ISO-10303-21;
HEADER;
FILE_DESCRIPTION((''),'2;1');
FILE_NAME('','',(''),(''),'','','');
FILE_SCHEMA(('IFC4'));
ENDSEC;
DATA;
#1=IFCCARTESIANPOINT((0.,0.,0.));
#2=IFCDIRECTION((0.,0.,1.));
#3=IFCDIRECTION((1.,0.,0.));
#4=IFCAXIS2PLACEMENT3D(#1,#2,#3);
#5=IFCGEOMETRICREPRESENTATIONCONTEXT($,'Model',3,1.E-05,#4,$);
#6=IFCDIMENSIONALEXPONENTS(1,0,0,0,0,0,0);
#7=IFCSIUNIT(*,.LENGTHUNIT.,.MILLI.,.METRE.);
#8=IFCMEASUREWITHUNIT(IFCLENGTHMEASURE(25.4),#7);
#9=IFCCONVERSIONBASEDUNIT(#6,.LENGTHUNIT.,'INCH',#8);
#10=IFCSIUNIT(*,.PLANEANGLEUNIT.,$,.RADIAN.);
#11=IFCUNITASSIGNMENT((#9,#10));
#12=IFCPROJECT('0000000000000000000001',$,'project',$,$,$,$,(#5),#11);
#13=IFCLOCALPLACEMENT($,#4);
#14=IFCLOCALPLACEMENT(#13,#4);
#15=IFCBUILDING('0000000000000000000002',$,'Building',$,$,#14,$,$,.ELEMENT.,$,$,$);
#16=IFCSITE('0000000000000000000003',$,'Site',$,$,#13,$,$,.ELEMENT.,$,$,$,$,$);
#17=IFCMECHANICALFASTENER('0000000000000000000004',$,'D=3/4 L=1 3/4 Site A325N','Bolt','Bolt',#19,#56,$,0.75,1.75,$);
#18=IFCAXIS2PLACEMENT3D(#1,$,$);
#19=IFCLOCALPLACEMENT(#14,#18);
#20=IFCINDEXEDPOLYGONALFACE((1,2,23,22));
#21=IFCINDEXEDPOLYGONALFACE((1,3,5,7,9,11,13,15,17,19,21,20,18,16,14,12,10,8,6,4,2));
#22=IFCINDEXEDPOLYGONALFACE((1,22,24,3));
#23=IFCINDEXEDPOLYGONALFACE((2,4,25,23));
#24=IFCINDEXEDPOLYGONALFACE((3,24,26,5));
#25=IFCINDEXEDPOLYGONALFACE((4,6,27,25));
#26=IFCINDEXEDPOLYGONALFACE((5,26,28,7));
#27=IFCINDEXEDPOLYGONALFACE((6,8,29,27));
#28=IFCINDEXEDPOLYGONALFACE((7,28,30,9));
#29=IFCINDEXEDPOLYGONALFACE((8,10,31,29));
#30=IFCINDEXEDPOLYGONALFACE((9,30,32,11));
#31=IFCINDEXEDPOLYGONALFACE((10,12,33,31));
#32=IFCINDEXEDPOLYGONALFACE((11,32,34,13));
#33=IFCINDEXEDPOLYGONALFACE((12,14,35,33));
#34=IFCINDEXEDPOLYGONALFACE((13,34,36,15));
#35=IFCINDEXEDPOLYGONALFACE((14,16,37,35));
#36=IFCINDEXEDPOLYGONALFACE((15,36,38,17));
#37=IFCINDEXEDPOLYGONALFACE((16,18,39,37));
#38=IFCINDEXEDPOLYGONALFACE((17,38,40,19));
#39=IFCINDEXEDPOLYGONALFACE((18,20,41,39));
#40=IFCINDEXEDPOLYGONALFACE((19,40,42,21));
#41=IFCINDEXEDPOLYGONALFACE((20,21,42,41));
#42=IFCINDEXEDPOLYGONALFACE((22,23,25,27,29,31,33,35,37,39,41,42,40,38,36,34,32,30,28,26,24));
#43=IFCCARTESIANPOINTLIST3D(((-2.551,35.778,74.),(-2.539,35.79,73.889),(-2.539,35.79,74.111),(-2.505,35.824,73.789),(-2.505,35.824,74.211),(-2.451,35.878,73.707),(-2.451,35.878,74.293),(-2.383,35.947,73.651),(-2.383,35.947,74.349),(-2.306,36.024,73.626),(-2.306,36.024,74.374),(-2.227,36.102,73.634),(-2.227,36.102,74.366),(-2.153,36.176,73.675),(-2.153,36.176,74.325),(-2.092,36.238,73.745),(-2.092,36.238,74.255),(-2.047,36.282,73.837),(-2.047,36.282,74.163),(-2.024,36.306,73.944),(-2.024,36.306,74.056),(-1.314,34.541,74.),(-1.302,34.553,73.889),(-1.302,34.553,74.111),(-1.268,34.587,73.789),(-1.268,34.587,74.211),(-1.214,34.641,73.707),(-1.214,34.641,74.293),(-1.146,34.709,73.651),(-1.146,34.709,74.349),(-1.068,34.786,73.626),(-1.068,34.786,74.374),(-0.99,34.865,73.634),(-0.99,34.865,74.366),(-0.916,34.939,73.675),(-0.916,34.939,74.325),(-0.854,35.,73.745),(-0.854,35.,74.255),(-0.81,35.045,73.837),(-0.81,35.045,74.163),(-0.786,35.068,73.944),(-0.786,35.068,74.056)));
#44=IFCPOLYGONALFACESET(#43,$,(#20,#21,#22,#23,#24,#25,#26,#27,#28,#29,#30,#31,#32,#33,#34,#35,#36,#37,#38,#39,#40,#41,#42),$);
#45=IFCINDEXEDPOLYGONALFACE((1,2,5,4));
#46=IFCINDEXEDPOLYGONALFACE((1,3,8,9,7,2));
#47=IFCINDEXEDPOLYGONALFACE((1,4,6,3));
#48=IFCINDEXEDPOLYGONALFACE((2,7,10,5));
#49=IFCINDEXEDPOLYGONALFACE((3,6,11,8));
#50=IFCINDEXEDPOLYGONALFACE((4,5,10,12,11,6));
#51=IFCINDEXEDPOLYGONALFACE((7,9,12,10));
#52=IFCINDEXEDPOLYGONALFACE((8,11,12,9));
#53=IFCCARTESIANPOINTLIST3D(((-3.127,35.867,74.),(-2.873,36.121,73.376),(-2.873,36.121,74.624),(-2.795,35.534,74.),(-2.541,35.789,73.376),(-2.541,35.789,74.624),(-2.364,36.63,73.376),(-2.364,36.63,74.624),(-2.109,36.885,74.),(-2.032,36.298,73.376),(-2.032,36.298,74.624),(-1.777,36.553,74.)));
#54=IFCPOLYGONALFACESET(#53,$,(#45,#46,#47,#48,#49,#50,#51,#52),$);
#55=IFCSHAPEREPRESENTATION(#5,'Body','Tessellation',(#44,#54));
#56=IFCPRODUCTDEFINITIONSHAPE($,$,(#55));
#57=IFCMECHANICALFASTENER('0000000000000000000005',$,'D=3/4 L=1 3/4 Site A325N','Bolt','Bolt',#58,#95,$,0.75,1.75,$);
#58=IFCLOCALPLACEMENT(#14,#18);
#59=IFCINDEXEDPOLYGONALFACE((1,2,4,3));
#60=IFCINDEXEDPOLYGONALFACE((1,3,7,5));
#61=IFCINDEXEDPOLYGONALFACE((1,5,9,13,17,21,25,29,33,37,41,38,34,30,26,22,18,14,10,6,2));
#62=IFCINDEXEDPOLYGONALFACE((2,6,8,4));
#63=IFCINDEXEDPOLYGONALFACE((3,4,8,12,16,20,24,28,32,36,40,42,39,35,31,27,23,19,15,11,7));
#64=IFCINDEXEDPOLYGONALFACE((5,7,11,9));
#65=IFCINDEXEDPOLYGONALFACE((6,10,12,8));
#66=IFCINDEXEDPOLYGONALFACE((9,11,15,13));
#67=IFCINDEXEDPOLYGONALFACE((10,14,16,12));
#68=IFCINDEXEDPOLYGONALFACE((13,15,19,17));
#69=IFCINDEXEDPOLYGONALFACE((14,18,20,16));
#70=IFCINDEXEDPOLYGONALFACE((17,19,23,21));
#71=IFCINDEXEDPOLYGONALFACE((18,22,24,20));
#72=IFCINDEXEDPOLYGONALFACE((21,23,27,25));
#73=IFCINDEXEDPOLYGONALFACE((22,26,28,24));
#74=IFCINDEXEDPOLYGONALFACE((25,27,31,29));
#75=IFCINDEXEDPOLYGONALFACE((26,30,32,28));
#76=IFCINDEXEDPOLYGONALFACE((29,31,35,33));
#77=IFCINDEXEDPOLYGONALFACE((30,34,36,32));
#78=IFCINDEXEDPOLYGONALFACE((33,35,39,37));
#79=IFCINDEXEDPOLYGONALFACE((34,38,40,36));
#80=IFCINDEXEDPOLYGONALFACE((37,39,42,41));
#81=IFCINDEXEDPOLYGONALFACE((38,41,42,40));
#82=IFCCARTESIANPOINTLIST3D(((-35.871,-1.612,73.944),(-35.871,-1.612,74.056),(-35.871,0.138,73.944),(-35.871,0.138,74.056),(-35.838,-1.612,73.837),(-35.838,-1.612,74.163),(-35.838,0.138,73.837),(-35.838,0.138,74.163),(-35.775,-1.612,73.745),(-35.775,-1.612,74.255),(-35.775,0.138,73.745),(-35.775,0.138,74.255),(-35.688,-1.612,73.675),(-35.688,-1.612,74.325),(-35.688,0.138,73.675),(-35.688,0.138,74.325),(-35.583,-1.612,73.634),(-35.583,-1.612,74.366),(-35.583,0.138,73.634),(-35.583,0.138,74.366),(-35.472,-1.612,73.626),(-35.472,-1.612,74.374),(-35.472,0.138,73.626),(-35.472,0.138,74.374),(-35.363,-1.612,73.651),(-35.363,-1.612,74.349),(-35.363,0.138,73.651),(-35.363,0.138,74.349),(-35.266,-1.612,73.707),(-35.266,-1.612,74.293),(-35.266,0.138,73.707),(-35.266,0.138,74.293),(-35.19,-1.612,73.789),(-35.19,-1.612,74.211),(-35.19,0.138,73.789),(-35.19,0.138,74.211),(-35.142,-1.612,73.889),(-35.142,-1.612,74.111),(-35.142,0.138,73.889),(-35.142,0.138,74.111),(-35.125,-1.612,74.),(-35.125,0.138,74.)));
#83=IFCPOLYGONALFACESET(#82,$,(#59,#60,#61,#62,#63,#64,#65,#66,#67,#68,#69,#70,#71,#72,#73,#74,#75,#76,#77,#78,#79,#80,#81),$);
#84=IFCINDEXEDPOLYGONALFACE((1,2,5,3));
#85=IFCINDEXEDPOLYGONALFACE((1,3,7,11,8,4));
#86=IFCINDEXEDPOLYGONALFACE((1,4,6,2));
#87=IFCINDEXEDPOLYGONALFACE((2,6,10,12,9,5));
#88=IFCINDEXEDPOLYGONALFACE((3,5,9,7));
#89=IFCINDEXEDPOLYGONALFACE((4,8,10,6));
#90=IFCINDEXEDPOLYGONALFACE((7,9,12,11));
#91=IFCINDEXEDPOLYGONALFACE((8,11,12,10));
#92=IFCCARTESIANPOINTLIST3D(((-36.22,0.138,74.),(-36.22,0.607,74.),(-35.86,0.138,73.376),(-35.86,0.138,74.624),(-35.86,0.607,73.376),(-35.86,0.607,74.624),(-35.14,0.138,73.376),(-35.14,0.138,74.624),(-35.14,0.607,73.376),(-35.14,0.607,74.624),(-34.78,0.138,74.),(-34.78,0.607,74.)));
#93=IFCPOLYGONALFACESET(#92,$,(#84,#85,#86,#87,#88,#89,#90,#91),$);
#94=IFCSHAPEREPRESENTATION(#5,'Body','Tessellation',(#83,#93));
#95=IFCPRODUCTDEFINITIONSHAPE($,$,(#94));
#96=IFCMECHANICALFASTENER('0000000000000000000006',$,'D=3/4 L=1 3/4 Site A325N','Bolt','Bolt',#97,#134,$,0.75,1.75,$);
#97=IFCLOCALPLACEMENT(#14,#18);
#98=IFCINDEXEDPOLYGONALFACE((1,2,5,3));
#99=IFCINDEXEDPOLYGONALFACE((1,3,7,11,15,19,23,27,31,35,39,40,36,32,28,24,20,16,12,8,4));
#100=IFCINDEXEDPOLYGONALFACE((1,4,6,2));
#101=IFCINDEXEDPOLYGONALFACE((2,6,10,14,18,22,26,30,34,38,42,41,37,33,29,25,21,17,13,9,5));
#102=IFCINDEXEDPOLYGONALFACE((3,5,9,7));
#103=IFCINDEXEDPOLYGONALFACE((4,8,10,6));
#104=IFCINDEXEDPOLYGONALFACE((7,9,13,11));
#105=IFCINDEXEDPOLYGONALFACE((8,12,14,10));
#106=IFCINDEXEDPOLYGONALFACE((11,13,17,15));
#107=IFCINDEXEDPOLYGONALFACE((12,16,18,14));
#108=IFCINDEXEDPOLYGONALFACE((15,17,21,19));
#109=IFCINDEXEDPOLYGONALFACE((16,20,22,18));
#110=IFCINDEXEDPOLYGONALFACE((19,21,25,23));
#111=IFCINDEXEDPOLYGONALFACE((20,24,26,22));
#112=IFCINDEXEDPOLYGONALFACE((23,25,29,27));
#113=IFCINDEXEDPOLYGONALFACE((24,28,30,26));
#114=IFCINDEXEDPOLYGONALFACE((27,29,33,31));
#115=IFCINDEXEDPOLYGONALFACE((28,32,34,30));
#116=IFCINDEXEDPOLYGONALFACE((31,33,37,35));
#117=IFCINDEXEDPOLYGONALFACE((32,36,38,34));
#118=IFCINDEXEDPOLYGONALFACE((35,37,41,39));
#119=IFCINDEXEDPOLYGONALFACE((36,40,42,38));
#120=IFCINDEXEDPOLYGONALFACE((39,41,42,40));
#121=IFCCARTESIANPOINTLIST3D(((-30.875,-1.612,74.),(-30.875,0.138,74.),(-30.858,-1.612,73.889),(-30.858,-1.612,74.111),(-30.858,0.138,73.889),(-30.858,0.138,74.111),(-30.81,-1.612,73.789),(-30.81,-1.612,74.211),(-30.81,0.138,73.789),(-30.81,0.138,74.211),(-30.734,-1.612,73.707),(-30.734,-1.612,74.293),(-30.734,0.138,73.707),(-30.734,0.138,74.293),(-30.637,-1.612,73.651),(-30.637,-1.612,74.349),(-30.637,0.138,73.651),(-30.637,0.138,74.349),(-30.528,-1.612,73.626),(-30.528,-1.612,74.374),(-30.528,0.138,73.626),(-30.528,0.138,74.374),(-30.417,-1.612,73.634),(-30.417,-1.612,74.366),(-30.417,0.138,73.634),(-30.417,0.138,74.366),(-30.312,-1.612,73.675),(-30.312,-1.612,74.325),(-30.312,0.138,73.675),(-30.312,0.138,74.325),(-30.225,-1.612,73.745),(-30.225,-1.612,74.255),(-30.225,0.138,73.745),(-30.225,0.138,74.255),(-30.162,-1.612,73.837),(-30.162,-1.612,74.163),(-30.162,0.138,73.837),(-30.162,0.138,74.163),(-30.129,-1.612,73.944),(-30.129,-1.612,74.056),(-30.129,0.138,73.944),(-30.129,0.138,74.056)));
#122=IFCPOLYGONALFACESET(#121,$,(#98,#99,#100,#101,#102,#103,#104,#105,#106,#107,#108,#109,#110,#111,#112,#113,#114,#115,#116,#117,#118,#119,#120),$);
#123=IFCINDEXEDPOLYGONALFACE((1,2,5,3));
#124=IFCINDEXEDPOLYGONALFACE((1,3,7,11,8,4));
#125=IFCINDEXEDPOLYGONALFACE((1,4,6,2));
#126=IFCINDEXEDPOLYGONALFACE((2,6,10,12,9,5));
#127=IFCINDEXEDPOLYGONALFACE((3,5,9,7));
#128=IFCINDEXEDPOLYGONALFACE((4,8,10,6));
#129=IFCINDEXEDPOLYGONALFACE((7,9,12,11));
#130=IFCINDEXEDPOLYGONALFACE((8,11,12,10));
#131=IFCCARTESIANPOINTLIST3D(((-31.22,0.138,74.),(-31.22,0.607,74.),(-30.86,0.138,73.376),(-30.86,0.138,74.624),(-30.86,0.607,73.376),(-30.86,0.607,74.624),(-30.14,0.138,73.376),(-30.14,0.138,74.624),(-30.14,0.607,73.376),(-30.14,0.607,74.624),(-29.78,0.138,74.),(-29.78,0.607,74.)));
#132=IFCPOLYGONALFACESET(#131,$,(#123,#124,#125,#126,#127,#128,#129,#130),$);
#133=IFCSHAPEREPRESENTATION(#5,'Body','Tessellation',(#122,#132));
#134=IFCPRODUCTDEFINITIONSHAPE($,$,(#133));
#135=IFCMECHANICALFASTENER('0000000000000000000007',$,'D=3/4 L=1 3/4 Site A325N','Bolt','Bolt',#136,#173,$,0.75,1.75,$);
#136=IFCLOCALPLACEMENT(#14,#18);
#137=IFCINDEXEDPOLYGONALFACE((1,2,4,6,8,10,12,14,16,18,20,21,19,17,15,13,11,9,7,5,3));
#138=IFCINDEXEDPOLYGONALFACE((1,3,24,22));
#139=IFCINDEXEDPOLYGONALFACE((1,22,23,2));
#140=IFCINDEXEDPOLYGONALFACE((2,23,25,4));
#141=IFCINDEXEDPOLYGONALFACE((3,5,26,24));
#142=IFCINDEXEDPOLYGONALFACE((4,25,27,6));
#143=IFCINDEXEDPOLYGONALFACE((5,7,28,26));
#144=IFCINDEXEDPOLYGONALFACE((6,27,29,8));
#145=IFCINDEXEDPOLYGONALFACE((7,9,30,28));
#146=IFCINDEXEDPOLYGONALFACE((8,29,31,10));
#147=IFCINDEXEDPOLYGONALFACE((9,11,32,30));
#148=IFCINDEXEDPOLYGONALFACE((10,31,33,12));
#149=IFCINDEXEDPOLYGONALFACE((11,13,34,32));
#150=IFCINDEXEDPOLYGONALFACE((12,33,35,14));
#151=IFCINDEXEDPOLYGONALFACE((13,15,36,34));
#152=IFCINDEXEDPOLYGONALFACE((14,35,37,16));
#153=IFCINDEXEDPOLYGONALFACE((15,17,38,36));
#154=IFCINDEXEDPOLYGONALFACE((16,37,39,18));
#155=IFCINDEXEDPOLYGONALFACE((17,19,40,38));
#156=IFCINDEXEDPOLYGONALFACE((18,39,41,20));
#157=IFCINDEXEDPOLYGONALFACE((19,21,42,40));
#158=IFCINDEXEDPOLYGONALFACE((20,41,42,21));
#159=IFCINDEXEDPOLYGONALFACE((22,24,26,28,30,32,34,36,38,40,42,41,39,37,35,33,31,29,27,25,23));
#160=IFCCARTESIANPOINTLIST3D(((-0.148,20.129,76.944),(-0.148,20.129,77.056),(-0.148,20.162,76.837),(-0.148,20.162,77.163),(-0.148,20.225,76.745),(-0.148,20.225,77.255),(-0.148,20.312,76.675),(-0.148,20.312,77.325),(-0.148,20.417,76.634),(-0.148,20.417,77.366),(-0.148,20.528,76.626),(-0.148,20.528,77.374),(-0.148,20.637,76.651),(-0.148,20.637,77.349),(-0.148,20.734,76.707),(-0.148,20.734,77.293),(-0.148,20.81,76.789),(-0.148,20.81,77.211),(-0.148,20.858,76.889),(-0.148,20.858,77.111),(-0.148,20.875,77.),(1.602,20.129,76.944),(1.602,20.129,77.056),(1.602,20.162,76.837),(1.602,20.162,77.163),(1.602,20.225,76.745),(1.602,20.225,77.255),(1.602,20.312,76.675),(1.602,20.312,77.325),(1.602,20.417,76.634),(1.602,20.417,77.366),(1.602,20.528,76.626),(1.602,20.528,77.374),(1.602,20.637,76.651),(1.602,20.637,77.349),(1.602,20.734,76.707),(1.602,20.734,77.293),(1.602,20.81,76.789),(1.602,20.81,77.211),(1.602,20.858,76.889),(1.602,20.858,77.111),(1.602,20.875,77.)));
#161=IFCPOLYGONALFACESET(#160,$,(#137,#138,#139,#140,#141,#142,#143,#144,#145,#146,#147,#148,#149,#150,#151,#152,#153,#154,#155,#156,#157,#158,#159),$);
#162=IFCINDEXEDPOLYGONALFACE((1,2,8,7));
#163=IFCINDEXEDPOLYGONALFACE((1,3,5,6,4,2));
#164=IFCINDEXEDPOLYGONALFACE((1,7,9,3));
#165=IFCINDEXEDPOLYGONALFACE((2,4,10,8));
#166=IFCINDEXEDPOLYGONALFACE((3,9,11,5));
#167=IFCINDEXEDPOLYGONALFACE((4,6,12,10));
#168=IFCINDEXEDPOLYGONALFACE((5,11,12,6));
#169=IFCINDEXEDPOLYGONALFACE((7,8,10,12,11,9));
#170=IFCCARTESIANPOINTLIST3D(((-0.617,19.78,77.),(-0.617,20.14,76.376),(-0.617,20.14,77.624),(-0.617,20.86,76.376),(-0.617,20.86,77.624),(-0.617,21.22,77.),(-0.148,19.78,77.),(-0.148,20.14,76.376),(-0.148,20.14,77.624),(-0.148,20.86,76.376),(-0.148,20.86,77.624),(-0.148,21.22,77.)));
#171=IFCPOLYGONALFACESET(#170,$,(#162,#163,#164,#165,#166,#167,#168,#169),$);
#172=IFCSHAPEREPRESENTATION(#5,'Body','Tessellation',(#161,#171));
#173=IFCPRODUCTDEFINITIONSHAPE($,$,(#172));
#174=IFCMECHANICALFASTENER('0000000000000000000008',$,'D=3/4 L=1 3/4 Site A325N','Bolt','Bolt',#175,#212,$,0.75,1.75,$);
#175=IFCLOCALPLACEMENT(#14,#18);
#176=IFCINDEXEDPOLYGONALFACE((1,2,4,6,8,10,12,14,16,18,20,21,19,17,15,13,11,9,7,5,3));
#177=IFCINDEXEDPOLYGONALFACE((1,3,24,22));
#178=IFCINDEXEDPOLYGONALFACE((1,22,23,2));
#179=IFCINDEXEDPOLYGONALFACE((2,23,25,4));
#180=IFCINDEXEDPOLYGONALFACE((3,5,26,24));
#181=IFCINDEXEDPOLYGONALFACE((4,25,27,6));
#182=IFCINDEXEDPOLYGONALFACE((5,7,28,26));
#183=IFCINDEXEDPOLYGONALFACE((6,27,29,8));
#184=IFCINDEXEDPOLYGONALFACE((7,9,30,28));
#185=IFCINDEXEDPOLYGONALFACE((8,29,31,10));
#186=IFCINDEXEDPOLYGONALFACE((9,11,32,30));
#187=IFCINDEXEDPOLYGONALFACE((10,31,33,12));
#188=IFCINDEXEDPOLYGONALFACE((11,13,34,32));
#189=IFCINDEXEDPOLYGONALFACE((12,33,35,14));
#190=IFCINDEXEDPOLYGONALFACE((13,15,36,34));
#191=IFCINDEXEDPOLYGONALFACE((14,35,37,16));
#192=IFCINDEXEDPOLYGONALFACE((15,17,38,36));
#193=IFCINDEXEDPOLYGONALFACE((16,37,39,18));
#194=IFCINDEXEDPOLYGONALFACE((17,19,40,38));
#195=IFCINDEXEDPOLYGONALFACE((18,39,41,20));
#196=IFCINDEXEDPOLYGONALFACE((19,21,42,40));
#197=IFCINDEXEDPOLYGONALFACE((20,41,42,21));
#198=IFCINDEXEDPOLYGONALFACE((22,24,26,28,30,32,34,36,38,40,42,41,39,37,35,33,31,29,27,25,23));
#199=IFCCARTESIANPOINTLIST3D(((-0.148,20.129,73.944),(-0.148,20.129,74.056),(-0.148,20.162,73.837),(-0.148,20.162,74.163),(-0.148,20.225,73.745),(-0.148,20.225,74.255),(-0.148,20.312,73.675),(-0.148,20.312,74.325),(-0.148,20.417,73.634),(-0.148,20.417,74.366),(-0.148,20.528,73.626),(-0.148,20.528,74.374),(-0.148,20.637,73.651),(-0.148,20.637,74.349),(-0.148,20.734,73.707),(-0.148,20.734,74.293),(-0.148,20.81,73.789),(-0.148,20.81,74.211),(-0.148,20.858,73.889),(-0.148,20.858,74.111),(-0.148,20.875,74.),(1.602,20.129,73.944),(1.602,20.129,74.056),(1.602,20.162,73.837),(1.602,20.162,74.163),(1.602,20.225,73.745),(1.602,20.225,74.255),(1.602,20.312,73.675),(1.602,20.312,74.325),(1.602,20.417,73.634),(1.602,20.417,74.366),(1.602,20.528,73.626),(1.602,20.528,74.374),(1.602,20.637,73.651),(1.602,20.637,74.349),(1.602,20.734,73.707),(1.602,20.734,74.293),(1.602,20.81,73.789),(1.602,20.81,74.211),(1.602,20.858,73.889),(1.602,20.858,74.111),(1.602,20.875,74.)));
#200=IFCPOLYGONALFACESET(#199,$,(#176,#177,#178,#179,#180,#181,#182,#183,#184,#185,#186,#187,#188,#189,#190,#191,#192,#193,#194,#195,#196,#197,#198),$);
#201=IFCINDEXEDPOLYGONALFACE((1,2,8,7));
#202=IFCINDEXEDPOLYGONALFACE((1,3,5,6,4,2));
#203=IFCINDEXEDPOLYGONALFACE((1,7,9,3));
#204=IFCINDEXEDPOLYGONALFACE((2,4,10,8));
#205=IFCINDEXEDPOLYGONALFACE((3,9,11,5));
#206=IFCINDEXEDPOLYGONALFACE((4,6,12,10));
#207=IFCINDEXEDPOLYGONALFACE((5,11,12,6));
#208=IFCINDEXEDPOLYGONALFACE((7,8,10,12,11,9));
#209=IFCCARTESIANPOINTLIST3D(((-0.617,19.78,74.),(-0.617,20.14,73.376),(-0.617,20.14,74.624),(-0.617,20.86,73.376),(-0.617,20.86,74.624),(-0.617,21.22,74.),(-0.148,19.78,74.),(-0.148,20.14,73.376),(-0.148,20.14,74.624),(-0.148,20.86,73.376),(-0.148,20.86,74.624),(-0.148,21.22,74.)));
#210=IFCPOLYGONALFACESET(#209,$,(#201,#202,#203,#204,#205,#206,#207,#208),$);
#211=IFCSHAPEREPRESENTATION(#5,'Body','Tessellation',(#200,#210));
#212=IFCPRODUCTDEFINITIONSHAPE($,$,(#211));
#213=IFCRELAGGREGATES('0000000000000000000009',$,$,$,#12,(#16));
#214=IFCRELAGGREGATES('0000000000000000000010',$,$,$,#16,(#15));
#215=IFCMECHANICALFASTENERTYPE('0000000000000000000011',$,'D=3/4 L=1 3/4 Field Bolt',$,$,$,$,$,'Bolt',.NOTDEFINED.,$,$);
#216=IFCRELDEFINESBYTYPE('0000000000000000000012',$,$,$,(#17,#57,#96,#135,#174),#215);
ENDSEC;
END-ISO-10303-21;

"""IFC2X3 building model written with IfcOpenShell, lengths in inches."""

from ifc_helpers import new_model, entity, si_unit, converted_unit, frame, origin_with_axes, origin_2d_with_axis, place, context, project, spatial, polyline, circle, outline, extrude, source, transform, mapped, type_object, type_shapes, element, save


model = new_model("IFC2X3")

# Units and contexts
model_context = context("Model", 3, precision=1e-05, world=origin_with_axes())
ifc_project = project(units=[converted_unit("LENGTHUNIT", "INCH", entity("IfcLengthMeasure", 25.4), si_unit("LENGTHUNIT", "METRE", prefix="MILLI"), dimensions=[1, 0, 0, 0, 0, 0, 0]), si_unit("PLANEANGLEUNIT", "RADIAN")], contexts=[model_context])

# Site, building
site_placement = place(None, origin_with_axes())
site = spatial("IfcSite", under=ifc_project, at=site_placement, Name="Site", CompositionType="ELEMENT")
building_placement = place(site_placement, origin_with_axes())
building = spatial("IfcBuilding", under=site, at=building_placement, Name="Building", CompositionType="ELEMENT")

# Shared definitions
assembly_1_placement = place(building_placement, frame((-38.0, 0.0, 77.0), z_axis=(0.0, 0.0, 1.0), x_axis=(0.707107, 0.707107, 0.0)))

# Mechanical fasteners
mechanical_fastener_type_1 = type_object("IfcMechanicalFastenerType", Name="D=3/4 L=1 3/4 Field Bolt", ElementType="Bolt")
shared_shape_1 = source(origin_with_axes(), model_context, "Body", "SweptSolid", [
    extrude(circle(Radius=0.375, at=origin_2d_with_axis()), frame((0.0, 0.0, 0.0), z_axis=(1.0, 0.0, 0.0), x_axis=(0.0, 1.0, 0.0)), (0.0, 0.0, 1.0), 1.75),
    extrude(outline(polyline([(-0.72, 0.0), (-0.36, 0.624), (0.36, 0.624), (0.72, 0.0), (0.36, -0.624), (-0.36, -0.624), (-0.72, 0.0)])), frame((0.0, 0.0, 0.0), z_axis=(1.0, 0.0, 0.0), x_axis=(0.0, 1.0, 0.0)), (0.0, 0.0, -1.0), 0.47),
])
type_shapes(mechanical_fastener_type_1, [shared_shape_1])
placement_1 = place(assembly_1_placement, frame((50.74, 0.233, -3.0), z_axis=(0.0, 0.0, -1.0), x_axis=(0.0, -1.0, 0.0)))
mechanical_fastener_1_placement = place(placement_1, origin_with_axes())
element("IfcMechanicalFastener", 1, at=mechanical_fastener_1_placement, type_object=mechanical_fastener_type_1, Name="D=3/4 L=1 3/4 Site A325N", Description="Bolt", ObjectType="Bolt", NominalDiameter=0.75, NominalLength=1.75, context=model_context, shape_type="MappedRepresentation", body=[
    mapped(shared_shape_1, transform((0.0, 0.0, 0.0), scale=1.0)),
])
placement_2 = place(building_placement, frame((-33.0, 0.0, 77.0), z_axis=(0.0, 0.0, 1.0), x_axis=(0.0, -1.0, 0.0)))
placement_3 = place(placement_2, frame((-0.138, -2.5, -6.0), z_axis=(0.0, 0.0, 1.0), x_axis=(1.0, 0.0, 0.0)))
mechanical_fastener_2_placement = place(placement_3, frame((0.0, 0.0, 3.0), z_axis=(0.0, 0.0, 1.0), x_axis=(1.0, 0.0, 0.0)))
element("IfcMechanicalFastener", 2, at=mechanical_fastener_2_placement, type_object=mechanical_fastener_type_1, Name="D=3/4 L=1 3/4 Site A325N", Description="Bolt", ObjectType="Bolt", NominalDiameter=0.75, NominalLength=1.75, context=model_context, shape_type="MappedRepresentation", body=[
    mapped(shared_shape_1, transform((0.0, 0.0, 0.0), scale=1.0)),
])
placement_4 = place(placement_2, frame((-0.138, 2.5, -3.0), z_axis=(0.0, 0.0, -1.0), x_axis=(1.0, 0.0, 0.0)))
mechanical_fastener_3_placement = place(placement_4, origin_with_axes())
element("IfcMechanicalFastener", 3, at=mechanical_fastener_3_placement, type_object=mechanical_fastener_type_1, Name="D=3/4 L=1 3/4 Site A325N", Description="Bolt", ObjectType="Bolt", NominalDiameter=0.75, NominalLength=1.75, context=model_context, shape_type="MappedRepresentation", body=[
    mapped(shared_shape_1, transform((0.0, 0.0, 0.0), scale=1.0)),
])
placement_5 = place(building_placement, frame((0.0, 23.0, 82.5), z_axis=(0.0, 0.0, 1.0), x_axis=(1.0, 0.0, 0.0)))
placement_6 = place(placement_5, frame((-0.148, -2.5, -8.5), z_axis=(0.0, 0.0, 1.0), x_axis=(1.0, 0.0, 0.0)))
for number, where, z_axis, x_axis, name in (
    (4, (0.0, 0.0, 3.0), (0.0, 0.0, 1.0), (1.0, 0.0, 0.0), "D=3/4 L=1 3/4 Site A325N"),
    (5, (0.0, 0.0, 0.0), (0.0, 0.0, 1.0), (1.0, 0.0, 0.0), "D=3/4 L=1 3/4 Site A325N"),
):
    element("IfcMechanicalFastener", number, at=place(placement_6, frame(where, z_axis=z_axis, x_axis=x_axis)), type_object=mechanical_fastener_type_1, Name=name, Description="Bolt", ObjectType="Bolt", NominalDiameter=0.75, NominalLength=1.75, context=model_context, shape_type="MappedRepresentation", body=[
        mapped(shared_shape_1, transform((0.0, 0.0, 0.0), scale=1.0)),
    ])

save(model, "model.ifc")
